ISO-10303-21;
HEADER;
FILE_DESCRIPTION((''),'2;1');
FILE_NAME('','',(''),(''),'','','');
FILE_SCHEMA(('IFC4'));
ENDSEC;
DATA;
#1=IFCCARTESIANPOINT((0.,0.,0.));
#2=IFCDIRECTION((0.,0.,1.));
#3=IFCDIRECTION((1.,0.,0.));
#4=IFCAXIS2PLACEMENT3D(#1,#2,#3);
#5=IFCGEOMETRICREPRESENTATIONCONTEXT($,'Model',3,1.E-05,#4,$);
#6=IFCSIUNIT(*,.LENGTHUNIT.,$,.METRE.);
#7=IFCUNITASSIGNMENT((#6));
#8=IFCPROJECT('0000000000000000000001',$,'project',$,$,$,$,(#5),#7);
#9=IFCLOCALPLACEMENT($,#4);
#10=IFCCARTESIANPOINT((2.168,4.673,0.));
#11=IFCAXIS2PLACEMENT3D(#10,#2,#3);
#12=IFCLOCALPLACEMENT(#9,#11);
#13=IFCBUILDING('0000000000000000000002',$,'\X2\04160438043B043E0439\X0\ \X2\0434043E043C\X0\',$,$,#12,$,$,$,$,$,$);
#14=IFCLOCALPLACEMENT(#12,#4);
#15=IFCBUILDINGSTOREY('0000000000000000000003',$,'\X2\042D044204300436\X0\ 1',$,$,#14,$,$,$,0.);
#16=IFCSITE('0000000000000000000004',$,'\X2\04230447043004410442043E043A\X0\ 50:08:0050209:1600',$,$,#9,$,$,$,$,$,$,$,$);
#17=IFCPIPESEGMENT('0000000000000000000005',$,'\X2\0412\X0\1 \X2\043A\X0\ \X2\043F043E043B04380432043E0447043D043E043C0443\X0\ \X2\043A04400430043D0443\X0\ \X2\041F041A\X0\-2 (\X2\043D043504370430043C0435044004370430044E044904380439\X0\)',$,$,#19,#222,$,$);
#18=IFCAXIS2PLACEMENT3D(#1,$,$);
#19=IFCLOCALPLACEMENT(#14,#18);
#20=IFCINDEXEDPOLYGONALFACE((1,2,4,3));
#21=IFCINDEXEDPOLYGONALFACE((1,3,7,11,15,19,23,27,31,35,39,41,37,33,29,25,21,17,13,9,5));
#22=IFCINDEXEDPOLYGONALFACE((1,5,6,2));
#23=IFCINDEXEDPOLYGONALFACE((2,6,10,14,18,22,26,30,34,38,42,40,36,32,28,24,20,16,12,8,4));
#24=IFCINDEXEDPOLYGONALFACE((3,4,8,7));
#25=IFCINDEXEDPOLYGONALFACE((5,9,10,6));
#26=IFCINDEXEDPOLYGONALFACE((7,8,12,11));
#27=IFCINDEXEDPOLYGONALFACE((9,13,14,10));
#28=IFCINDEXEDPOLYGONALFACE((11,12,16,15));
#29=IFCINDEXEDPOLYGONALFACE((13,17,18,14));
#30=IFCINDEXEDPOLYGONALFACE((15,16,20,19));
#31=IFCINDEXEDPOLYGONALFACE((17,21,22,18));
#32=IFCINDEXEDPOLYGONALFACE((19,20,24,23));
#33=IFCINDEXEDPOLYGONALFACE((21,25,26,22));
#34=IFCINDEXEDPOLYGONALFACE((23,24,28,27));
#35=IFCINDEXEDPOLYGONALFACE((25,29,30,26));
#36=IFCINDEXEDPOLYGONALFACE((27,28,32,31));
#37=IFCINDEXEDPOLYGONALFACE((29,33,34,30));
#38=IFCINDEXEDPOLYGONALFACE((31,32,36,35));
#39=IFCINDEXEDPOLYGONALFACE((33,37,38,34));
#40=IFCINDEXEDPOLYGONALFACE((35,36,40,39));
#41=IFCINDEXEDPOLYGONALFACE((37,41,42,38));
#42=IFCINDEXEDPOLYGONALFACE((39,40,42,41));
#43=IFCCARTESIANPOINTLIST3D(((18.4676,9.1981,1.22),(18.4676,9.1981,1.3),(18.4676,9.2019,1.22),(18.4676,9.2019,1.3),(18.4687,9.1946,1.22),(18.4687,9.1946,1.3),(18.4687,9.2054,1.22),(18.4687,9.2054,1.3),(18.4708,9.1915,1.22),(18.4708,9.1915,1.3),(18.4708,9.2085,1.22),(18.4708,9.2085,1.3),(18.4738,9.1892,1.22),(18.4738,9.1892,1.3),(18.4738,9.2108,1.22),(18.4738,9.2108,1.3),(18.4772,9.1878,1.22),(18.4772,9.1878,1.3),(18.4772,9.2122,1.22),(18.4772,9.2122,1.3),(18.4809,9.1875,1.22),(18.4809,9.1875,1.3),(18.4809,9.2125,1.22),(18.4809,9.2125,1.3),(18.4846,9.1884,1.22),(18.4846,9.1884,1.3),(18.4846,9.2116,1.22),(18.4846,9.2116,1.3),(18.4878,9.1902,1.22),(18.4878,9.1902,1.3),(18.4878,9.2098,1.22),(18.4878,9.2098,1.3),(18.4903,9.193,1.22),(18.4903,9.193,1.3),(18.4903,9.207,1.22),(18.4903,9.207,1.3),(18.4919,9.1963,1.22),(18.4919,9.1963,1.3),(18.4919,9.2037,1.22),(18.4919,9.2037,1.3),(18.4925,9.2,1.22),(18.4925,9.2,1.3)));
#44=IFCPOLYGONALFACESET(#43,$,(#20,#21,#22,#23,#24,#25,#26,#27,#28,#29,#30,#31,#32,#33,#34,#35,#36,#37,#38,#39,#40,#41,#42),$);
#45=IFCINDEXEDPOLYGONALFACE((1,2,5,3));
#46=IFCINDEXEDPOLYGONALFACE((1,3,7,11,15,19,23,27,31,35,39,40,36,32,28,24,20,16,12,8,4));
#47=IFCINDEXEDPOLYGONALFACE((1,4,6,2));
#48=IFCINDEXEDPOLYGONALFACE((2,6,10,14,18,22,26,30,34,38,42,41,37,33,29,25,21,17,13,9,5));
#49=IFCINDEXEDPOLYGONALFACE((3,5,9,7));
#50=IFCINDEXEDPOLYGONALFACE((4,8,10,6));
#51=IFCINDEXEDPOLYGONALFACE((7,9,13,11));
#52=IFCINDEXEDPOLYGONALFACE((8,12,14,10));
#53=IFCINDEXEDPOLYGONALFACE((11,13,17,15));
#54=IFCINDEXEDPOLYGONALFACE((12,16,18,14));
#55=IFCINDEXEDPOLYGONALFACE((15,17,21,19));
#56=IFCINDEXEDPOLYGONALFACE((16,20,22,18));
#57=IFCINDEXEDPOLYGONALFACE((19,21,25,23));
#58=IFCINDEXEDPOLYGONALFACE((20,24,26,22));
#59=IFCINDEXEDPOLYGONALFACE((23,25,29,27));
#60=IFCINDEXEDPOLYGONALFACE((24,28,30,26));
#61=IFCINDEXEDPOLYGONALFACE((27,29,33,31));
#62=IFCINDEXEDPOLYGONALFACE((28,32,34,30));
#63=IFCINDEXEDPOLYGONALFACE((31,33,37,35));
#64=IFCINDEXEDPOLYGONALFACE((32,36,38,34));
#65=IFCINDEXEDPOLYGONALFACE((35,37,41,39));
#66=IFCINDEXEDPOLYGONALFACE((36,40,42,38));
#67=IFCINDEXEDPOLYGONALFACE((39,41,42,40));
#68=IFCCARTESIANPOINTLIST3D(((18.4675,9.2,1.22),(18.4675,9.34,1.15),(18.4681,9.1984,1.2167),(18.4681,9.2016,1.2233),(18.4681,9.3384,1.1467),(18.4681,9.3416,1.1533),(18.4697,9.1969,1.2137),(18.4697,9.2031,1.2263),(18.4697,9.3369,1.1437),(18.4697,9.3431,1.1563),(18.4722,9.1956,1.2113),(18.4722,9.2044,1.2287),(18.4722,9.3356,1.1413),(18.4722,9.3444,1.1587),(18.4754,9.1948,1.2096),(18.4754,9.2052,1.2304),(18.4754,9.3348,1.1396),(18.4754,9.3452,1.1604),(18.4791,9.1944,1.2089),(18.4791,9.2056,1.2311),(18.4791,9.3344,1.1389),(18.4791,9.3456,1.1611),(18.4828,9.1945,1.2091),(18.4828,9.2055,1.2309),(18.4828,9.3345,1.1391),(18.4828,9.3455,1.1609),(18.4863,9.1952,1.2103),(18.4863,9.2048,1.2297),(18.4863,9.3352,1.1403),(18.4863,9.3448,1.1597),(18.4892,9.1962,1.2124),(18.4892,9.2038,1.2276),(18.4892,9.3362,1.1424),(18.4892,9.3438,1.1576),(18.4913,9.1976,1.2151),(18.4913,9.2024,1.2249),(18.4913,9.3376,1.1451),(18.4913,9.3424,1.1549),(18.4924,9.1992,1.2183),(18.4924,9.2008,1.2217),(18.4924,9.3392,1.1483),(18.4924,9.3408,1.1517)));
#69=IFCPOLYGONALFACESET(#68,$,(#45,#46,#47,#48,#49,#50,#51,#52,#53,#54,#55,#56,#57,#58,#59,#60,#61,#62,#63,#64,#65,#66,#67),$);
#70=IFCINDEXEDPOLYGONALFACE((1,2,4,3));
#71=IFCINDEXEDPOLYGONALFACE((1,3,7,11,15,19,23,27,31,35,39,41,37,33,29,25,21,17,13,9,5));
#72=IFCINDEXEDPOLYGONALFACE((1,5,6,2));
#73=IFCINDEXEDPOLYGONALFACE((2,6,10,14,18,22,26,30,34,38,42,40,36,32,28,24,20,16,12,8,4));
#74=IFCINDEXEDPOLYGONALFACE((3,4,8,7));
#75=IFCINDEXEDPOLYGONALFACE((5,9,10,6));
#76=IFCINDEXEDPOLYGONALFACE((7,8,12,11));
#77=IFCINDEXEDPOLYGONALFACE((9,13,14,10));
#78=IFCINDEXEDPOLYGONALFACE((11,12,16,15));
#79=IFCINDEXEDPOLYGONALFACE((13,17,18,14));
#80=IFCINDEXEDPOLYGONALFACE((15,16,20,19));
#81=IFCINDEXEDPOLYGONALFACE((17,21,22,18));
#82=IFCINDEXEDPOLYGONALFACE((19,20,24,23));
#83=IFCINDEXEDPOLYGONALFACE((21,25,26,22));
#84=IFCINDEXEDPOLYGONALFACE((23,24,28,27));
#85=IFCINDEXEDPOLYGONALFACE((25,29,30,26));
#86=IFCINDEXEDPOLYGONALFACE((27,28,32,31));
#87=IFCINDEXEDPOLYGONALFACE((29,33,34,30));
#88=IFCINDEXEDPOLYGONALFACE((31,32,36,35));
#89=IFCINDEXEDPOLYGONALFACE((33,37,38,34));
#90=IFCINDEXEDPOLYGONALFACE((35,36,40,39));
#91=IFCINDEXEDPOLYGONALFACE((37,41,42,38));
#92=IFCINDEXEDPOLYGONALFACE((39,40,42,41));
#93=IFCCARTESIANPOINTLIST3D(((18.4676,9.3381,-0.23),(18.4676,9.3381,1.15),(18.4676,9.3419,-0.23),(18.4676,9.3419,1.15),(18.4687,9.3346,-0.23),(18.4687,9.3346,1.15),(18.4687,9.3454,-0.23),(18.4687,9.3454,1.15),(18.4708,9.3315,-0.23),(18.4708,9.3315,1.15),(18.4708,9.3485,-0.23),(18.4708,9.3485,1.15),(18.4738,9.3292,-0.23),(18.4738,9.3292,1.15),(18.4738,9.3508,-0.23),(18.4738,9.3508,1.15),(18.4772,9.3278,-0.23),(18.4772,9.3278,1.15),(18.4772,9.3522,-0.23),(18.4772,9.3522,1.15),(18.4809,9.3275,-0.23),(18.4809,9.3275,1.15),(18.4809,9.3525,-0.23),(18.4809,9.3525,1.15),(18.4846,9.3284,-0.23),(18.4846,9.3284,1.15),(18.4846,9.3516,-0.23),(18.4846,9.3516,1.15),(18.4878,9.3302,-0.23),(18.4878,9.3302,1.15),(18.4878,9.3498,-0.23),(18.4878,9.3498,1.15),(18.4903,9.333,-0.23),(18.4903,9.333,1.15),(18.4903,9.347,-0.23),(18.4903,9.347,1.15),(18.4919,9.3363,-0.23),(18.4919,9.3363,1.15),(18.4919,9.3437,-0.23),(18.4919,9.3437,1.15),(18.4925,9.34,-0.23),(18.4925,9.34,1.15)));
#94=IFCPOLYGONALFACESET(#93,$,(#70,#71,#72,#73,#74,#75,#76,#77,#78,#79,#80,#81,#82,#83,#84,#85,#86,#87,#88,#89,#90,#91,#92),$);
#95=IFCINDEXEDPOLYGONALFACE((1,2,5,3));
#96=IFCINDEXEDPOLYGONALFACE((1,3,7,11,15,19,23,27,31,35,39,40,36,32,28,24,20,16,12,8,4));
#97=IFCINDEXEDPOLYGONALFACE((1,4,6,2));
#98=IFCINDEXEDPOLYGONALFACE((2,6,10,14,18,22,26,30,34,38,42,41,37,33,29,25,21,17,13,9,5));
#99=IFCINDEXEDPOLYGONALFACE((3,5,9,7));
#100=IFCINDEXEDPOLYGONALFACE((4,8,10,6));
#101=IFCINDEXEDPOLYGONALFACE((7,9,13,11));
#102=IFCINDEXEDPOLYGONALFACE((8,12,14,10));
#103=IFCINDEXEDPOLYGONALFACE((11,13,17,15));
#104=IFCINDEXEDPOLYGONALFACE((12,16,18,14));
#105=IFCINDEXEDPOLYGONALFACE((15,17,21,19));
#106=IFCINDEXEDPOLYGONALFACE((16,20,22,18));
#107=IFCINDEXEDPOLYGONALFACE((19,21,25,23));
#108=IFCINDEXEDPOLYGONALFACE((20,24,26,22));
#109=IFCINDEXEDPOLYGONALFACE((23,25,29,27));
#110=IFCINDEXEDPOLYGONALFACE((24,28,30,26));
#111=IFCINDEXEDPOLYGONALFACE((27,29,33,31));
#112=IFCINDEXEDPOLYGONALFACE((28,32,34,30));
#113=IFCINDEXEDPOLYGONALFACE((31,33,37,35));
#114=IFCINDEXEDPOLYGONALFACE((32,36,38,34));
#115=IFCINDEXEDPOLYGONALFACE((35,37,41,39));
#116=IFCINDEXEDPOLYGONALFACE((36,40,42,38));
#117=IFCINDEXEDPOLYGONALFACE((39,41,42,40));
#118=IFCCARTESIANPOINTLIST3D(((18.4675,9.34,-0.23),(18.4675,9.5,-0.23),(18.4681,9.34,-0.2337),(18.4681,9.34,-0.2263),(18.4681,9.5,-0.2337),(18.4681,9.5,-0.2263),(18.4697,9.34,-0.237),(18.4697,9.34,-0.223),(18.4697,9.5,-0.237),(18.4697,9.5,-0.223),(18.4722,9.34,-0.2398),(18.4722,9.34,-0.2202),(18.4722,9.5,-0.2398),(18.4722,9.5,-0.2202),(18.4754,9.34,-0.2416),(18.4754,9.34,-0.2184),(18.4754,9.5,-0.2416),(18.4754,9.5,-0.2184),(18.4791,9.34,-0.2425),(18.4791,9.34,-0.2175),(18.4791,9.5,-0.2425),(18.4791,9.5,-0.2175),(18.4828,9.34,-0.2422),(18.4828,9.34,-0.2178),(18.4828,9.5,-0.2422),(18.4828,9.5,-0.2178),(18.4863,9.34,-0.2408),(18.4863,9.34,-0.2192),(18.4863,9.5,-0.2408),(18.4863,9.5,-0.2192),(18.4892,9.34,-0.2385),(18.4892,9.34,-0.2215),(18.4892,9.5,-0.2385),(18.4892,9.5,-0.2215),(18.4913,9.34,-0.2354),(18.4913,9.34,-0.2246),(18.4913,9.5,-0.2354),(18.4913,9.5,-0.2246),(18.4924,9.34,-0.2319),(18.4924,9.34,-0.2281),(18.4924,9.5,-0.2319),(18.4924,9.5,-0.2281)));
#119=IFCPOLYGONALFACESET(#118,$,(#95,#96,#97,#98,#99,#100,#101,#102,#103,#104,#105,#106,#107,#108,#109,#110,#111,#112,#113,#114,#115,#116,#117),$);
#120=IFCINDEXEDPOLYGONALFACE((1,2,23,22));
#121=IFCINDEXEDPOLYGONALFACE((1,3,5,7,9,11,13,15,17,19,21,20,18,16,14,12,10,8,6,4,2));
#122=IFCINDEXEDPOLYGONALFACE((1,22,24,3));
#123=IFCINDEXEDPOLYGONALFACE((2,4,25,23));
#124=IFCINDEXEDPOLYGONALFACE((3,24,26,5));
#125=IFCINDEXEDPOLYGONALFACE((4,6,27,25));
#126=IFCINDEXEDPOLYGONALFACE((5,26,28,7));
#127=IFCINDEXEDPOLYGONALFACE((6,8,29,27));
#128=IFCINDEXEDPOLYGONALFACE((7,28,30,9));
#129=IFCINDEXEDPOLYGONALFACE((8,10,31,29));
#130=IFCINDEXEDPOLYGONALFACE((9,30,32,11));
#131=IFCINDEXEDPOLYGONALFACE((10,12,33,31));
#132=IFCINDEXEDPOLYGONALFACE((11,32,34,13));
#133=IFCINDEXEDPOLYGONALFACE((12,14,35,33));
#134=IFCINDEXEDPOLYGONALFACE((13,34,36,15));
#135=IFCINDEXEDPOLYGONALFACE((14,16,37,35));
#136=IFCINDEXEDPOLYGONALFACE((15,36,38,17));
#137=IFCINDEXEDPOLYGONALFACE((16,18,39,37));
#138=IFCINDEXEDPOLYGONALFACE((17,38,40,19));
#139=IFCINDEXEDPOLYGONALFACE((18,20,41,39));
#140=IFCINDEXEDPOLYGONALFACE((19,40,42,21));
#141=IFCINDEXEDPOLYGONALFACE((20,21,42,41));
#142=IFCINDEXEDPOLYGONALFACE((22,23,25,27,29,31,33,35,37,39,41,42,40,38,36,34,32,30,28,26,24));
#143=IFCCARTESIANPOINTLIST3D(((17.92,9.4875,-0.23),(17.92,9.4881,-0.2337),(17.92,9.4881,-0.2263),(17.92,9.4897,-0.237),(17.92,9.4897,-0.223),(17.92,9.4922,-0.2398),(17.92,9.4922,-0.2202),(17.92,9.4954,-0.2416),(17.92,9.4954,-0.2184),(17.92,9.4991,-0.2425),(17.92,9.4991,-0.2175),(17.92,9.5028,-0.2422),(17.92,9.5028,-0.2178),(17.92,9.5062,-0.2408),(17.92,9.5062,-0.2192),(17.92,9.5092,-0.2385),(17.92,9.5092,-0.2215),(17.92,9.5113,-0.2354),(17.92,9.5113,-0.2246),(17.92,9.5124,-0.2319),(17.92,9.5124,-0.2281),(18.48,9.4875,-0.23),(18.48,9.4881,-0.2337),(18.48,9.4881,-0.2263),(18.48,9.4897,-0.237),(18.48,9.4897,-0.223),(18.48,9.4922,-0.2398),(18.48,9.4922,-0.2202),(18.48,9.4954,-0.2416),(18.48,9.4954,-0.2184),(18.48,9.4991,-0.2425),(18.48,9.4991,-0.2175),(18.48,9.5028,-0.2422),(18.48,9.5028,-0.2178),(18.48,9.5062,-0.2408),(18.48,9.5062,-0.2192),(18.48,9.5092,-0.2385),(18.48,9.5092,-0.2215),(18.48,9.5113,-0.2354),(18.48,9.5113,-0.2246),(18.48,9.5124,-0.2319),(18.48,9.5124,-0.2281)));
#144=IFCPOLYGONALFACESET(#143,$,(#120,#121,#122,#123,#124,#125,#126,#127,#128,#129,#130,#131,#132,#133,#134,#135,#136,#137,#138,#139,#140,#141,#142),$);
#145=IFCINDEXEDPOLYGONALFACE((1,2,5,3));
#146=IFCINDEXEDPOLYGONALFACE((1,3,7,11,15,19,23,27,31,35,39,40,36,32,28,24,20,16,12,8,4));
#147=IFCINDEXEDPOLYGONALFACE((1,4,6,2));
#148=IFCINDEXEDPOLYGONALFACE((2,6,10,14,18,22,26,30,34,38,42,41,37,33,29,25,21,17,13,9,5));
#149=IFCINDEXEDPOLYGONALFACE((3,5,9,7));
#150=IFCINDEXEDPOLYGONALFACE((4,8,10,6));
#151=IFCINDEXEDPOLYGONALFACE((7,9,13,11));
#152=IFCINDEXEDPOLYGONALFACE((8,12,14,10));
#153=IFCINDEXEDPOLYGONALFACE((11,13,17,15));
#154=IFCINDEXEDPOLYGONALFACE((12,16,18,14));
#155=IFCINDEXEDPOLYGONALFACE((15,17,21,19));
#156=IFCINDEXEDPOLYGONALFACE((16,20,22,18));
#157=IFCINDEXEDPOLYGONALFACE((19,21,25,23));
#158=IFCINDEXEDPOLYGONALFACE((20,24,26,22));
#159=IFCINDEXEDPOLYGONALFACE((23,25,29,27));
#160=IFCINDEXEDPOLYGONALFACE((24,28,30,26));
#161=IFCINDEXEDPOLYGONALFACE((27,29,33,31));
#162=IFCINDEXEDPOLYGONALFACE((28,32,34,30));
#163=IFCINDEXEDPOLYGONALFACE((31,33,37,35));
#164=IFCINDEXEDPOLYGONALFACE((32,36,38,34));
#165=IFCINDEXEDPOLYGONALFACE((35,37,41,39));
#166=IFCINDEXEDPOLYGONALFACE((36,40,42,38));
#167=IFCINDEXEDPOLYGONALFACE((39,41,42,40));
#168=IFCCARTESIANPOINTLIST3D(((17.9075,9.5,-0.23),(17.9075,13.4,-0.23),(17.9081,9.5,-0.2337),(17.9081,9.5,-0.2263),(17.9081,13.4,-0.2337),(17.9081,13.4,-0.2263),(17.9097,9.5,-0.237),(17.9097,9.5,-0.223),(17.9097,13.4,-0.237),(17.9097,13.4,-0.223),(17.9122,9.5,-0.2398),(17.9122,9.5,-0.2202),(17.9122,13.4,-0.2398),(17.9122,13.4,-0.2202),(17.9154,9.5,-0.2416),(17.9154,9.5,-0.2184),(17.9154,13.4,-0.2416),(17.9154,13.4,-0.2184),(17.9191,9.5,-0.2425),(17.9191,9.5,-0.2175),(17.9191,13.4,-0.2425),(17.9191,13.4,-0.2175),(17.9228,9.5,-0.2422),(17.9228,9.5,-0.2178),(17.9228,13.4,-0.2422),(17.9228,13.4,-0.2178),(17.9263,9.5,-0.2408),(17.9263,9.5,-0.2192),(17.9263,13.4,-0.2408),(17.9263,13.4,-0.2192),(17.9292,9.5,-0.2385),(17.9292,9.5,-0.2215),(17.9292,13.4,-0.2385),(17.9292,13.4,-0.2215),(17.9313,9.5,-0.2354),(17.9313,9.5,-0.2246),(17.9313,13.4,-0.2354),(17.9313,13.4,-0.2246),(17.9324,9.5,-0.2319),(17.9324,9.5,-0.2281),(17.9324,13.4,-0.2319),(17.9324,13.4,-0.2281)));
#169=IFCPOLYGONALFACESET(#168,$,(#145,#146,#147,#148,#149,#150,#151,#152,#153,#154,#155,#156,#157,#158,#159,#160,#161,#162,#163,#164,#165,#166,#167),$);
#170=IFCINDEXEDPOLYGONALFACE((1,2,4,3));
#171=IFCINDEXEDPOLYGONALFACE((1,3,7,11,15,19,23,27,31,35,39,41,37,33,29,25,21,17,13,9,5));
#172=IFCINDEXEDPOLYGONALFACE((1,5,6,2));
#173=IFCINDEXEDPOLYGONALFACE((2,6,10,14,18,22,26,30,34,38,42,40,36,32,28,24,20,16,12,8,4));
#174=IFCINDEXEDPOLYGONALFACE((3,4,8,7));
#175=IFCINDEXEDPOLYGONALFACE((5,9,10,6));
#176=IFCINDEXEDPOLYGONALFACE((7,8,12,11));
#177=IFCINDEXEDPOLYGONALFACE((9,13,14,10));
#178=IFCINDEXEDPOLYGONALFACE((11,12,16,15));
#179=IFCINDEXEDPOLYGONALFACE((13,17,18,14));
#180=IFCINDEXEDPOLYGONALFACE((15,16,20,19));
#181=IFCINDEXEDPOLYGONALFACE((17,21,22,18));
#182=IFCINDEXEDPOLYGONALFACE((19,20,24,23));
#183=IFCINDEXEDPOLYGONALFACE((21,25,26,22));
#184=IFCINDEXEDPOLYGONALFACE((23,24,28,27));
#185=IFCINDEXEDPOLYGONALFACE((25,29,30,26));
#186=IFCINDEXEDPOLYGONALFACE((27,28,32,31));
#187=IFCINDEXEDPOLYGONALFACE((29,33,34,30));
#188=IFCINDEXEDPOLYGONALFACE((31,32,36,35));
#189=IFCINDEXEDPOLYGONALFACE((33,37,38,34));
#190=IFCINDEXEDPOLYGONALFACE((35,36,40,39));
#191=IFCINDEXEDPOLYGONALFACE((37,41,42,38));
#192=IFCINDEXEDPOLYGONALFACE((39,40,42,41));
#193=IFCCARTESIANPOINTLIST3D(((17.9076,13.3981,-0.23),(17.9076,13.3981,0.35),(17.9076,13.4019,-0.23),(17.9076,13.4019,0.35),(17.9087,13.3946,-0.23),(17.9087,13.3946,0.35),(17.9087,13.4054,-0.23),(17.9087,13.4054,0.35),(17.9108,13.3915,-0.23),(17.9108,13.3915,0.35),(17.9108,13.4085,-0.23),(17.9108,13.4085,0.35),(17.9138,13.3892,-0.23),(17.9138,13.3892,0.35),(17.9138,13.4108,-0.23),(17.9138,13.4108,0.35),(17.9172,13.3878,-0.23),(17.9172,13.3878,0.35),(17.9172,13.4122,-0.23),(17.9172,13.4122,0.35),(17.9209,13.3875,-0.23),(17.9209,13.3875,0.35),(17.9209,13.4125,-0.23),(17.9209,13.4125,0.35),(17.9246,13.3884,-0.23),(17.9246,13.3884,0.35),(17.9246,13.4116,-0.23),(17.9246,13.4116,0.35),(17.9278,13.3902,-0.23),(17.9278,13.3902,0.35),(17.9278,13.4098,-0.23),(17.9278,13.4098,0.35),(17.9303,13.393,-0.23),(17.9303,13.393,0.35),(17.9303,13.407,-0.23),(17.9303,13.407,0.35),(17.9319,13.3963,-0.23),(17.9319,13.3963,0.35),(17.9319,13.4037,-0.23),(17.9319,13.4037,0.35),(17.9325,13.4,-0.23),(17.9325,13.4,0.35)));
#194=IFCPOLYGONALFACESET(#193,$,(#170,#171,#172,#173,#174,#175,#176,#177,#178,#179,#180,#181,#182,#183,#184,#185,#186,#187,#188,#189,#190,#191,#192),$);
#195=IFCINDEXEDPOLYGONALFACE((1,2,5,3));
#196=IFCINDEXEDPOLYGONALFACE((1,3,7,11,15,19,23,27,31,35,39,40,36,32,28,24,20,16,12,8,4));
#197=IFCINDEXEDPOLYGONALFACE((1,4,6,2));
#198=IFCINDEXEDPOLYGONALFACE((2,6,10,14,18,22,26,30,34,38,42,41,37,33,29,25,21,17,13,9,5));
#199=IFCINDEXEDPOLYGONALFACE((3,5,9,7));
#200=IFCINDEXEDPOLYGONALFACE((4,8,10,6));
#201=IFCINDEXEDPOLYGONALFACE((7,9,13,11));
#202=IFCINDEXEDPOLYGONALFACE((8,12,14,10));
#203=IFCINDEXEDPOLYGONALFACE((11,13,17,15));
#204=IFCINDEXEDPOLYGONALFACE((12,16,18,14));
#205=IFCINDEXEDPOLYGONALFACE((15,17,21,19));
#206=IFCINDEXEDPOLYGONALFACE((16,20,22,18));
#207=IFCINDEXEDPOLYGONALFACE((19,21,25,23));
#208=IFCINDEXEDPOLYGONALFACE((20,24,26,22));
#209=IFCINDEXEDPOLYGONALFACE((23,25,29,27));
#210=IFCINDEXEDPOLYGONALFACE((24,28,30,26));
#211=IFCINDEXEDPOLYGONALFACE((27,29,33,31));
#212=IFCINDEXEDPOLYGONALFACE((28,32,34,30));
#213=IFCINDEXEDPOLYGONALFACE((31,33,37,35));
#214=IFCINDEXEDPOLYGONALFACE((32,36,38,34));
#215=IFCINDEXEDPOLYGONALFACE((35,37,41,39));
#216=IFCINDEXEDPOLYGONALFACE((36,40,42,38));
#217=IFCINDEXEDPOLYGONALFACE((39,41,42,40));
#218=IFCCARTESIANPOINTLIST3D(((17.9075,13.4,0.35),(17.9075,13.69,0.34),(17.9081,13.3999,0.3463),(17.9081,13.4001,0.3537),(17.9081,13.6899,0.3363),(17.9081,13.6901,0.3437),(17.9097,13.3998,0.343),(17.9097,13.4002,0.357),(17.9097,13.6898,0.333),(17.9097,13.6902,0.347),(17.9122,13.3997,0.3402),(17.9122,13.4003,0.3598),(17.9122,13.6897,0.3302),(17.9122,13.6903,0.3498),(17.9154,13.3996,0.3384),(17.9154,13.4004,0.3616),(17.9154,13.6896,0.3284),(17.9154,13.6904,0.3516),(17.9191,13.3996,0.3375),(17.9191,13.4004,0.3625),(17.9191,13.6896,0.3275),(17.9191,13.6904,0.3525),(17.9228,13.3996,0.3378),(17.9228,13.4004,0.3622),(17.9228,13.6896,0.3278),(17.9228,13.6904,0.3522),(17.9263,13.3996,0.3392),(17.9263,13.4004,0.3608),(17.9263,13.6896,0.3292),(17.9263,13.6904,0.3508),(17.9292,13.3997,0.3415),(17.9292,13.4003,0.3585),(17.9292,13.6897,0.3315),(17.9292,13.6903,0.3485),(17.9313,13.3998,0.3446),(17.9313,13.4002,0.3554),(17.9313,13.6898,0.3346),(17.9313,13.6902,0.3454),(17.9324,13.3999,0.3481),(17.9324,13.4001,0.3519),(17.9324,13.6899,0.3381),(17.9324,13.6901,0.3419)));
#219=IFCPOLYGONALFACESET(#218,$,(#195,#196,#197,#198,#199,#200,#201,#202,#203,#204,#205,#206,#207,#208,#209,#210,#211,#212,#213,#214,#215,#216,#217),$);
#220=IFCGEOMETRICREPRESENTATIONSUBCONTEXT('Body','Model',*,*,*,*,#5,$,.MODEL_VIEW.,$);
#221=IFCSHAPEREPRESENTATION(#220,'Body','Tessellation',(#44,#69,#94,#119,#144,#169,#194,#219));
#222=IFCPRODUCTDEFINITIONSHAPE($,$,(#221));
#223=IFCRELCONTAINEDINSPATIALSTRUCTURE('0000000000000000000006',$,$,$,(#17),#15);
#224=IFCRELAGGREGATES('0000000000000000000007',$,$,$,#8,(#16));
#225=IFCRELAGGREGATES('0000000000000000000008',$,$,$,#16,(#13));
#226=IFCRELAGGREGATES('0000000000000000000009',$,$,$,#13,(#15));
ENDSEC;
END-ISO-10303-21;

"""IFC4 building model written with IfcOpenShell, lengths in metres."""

from ifc_helpers import new_model, si_unit, frame, origin_with_axes, origin_2d, place, context, subcontext, project, spatial, circle, extrude, element, save


model = new_model("IFC4")

# Units and contexts
model_context = context("Model", 3, precision=1e-05, world=origin_with_axes())
body_context = subcontext(model_context, "Body", "Model", "MODEL_VIEW")
ifc_project = project(units=[si_unit("LENGTHUNIT", "METRE")], contexts=[model_context])

# Site, building, storey
site_placement = place(None, origin_with_axes())
site = spatial("IfcSite", under=ifc_project, at=site_placement, Name="Участок 50:08:0050209:1600")
building_placement = place(site_placement, frame((2.168, 4.673, 0.0), z_axis=(0.0, 0.0, 1.0), x_axis=(1.0, 0.0, 0.0)))
building = spatial("IfcBuilding", under=site, at=building_placement, Name="Жилой дом")
storey_placement = place(building_placement, origin_with_axes())
storey = spatial("IfcBuildingStorey", under=building, at=storey_placement, Name="Этаж 1", Elevation=0.0)

# Pipe segment
pipe_segment_1_placement = place(storey_placement, origin_with_axes())
element("IfcPipeSegment", 1, at=pipe_segment_1_placement, inside=storey, Name="В1 к поливочному крану ПК-2 (незамерзающий)", context=body_context, shape_type="SweptSolid", body=[
    extrude(circle(Radius=0.0125, at=origin_2d()), frame((18.48, 9.2, 1.3), z_axis=(0.0, 0.0, -1.0), x_axis=(1.0, 0.0, 0.0)), (0.0, 0.0, 1.0), 0.08),
    extrude(circle(Radius=0.0125, at=origin_2d()), frame((18.48, 9.2, 1.22), z_axis=(0.0, 0.894427, -0.447214), x_axis=(-1.0, 0.0, 0.0)), (0.0, 0.0, 1.0), 0.1565),
    extrude(circle(Radius=0.0125, at=origin_2d()), frame((18.48, 9.34, 1.15), z_axis=(0.0, 0.0, -1.0), x_axis=(1.0, 0.0, 0.0)), (0.0, 0.0, 1.0), 1.38),
    extrude(circle(Radius=0.0125, at=origin_2d()), frame((18.48, 9.34, -0.23), z_axis=(0.0, 1.0, 0.0), x_axis=(-1.0, 0.0, 0.0)), (0.0, 0.0, 1.0), 0.16),
    extrude(circle(Radius=0.0125, at=origin_2d()), frame((18.48, 9.5, -0.23), z_axis=(-1.0, 0.0, 0.0), x_axis=(0.0, -1.0, 0.0)), (0.0, 0.0, 1.0), 0.56),
    extrude(circle(Radius=0.0125, at=origin_2d()), frame((17.92, 9.5, -0.23), z_axis=(0.0, 1.0, 0.0), x_axis=(-1.0, 0.0, 0.0)), (0.0, 0.0, 1.0), 3.9),
    extrude(circle(Radius=0.0125, at=origin_2d()), frame((17.92, 13.4, -0.23), z_axis=(0.0, 0.0, 1.0), x_axis=(1.0, 0.0, 0.0)), (0.0, 0.0, 1.0), 0.58),
    extrude(circle(Radius=0.0125, at=origin_2d()), frame((17.92, 13.4, 0.35), z_axis=(0.0, 0.999406, -0.034462), x_axis=(-1.0, 0.0, 0.0)), (0.0, 0.0, 1.0), 0.2902),
])

save(model, "model.ifc")
